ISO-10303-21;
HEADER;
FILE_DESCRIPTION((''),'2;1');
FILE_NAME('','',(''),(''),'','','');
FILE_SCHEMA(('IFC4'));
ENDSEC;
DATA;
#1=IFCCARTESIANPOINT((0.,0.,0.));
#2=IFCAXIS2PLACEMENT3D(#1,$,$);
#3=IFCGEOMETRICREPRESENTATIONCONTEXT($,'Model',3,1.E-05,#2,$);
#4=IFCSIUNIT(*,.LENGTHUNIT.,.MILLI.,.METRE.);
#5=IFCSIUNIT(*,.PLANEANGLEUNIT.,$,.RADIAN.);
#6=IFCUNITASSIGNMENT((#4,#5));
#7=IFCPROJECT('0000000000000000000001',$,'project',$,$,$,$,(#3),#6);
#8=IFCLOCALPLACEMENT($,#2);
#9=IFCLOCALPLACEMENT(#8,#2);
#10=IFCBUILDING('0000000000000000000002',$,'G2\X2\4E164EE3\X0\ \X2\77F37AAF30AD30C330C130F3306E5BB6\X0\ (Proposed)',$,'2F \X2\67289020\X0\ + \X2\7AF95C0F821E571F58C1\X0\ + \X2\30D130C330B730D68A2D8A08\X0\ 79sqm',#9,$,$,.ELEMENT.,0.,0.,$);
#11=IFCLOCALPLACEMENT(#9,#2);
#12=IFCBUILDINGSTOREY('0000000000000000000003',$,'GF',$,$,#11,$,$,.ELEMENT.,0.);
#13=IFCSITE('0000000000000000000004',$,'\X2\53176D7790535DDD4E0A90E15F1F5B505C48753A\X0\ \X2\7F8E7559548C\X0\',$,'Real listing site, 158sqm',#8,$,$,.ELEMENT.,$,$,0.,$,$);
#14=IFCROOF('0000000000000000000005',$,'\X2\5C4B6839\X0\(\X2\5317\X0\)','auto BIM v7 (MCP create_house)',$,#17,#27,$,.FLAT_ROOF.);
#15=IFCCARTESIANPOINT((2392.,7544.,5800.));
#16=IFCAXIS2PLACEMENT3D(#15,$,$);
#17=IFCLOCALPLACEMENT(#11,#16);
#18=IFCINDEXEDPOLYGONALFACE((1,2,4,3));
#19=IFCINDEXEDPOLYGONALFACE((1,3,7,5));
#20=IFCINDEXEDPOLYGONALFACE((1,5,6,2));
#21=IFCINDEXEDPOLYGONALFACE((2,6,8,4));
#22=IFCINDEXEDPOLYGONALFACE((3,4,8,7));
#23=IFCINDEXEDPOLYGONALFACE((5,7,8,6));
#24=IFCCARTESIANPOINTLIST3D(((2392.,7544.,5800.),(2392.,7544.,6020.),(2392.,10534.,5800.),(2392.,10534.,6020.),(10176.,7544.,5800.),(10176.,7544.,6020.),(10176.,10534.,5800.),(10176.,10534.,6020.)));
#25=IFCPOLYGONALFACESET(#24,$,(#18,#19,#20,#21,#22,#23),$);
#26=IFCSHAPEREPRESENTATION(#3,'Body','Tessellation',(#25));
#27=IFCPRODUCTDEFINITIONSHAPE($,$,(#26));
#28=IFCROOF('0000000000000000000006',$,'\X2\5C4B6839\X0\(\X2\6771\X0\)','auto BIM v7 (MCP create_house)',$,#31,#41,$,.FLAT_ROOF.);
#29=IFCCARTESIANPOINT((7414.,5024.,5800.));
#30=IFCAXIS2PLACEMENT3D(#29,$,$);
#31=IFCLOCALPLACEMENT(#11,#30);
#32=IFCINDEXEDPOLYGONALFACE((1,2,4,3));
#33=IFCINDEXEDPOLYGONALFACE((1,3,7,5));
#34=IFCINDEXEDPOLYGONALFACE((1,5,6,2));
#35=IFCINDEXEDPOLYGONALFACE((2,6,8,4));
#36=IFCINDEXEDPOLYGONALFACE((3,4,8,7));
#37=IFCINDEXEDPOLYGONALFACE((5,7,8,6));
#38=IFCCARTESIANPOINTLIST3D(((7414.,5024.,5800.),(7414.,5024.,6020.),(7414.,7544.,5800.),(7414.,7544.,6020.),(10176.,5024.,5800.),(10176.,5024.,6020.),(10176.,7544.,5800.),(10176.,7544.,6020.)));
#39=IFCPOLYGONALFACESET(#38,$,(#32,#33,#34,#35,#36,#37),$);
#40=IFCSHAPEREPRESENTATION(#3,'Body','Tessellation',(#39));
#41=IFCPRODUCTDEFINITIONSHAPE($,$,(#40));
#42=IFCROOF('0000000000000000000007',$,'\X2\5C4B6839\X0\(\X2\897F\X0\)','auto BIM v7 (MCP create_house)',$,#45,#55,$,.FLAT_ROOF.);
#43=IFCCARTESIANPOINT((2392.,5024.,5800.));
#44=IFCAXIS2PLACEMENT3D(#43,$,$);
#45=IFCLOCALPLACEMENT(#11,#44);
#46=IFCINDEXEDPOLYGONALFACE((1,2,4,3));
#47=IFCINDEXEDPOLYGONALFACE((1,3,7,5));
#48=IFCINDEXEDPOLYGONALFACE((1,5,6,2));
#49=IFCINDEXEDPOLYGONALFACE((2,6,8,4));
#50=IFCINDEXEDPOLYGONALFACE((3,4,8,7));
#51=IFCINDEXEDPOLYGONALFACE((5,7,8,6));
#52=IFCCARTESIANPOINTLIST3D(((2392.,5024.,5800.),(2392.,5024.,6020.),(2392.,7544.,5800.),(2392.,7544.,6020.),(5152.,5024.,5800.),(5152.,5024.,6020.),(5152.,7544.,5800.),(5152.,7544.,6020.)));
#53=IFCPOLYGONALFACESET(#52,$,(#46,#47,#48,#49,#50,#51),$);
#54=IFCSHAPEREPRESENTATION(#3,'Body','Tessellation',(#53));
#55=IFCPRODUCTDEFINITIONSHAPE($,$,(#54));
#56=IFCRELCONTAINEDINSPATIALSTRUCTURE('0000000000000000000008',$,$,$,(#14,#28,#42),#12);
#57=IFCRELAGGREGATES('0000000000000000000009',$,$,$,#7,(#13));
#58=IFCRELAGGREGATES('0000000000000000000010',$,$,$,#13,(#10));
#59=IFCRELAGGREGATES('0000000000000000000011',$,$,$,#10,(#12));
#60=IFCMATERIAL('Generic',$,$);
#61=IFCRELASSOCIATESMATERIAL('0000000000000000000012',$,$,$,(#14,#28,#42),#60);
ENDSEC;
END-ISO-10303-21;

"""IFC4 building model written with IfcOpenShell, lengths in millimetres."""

from ifc_helpers import new_model, si_unit, frame, frame_2d, origin, place, context, project, spatial, rectangle, extrude, material, element, save


model = new_model("IFC4")

# Units and contexts
model_context = context("Model", 3, precision=1e-05, world=origin())
ifc_project = project(units=[si_unit("LENGTHUNIT", "METRE", prefix="MILLI"), si_unit("PLANEANGLEUNIT", "RADIAN")], contexts=[model_context])

# Site, building, storey
site_placement = place(None, origin())
site = spatial("IfcSite", under=ifc_project, at=site_placement, Name="北海道川上郡弟子屈町 美留和", ObjectType="Real listing site, 158sqm", CompositionType="ELEMENT", RefElevation=0.0)
building_placement = place(site_placement, origin())
building = spatial("IfcBuilding", under=site, at=building_placement, Name="G2世代 石窯キッチンの家 (Proposed)", ObjectType="2F 木造 + 竹小舞土壁 + パッシブ設計 79sqm", CompositionType="ELEMENT", ElevationOfRefHeight=0.0, ElevationOfTerrain=0.0)
storey_placement = place(building_placement, origin())
storey = spatial("IfcBuildingStorey", under=building, at=storey_placement, Name="GF", CompositionType="ELEMENT", Elevation=0.0)

# Shared definitions
ifc_material = material(Name="Generic")

# Roofs
roof_1_placement = place(storey_placement, frame((2392.0, 7544.0, 5800.0)))
element("IfcRoof", 1, at=roof_1_placement, inside=storey, material=ifc_material, Name="屋根(北)", Description="auto BIM v7 (MCP create_house)", PredefinedType="FLAT_ROOF", context=model_context, shape_type="SweptSolid", body=[
    extrude(rectangle(XDim=7784.0, YDim=2990.0, at=frame_2d((3892.0, 1495.0))), frame((2392.0, 7544.0, 5800.0)), (0.0, 0.0, 1.0), 220.0),
])
roof_2_placement = place(storey_placement, frame((7414.0, 5024.0, 5800.0)))
element("IfcRoof", 2, at=roof_2_placement, inside=storey, material=ifc_material, Name="屋根(東)", Description="auto BIM v7 (MCP create_house)", PredefinedType="FLAT_ROOF", context=model_context, shape_type="SweptSolid", body=[
    extrude(rectangle(XDim=2762.0, YDim=2520.0, at=frame_2d((1381.0, 1260.0))), frame((7414.0, 5024.0, 5800.0)), (0.0, 0.0, 1.0), 220.0),
])
roof_3_placement = place(storey_placement, frame((2392.0, 5024.0, 5800.0)))
element("IfcRoof", 3, at=roof_3_placement, inside=storey, material=ifc_material, Name="屋根(西)", Description="auto BIM v7 (MCP create_house)", PredefinedType="FLAT_ROOF", context=model_context, shape_type="SweptSolid", body=[
    extrude(rectangle(XDim=2760.0, YDim=2520.0, at=frame_2d((1380.0, 1260.0))), frame((2392.0, 5024.0, 5800.0)), (0.0, 0.0, 1.0), 220.0),
])

save(model, "model.ifc")
